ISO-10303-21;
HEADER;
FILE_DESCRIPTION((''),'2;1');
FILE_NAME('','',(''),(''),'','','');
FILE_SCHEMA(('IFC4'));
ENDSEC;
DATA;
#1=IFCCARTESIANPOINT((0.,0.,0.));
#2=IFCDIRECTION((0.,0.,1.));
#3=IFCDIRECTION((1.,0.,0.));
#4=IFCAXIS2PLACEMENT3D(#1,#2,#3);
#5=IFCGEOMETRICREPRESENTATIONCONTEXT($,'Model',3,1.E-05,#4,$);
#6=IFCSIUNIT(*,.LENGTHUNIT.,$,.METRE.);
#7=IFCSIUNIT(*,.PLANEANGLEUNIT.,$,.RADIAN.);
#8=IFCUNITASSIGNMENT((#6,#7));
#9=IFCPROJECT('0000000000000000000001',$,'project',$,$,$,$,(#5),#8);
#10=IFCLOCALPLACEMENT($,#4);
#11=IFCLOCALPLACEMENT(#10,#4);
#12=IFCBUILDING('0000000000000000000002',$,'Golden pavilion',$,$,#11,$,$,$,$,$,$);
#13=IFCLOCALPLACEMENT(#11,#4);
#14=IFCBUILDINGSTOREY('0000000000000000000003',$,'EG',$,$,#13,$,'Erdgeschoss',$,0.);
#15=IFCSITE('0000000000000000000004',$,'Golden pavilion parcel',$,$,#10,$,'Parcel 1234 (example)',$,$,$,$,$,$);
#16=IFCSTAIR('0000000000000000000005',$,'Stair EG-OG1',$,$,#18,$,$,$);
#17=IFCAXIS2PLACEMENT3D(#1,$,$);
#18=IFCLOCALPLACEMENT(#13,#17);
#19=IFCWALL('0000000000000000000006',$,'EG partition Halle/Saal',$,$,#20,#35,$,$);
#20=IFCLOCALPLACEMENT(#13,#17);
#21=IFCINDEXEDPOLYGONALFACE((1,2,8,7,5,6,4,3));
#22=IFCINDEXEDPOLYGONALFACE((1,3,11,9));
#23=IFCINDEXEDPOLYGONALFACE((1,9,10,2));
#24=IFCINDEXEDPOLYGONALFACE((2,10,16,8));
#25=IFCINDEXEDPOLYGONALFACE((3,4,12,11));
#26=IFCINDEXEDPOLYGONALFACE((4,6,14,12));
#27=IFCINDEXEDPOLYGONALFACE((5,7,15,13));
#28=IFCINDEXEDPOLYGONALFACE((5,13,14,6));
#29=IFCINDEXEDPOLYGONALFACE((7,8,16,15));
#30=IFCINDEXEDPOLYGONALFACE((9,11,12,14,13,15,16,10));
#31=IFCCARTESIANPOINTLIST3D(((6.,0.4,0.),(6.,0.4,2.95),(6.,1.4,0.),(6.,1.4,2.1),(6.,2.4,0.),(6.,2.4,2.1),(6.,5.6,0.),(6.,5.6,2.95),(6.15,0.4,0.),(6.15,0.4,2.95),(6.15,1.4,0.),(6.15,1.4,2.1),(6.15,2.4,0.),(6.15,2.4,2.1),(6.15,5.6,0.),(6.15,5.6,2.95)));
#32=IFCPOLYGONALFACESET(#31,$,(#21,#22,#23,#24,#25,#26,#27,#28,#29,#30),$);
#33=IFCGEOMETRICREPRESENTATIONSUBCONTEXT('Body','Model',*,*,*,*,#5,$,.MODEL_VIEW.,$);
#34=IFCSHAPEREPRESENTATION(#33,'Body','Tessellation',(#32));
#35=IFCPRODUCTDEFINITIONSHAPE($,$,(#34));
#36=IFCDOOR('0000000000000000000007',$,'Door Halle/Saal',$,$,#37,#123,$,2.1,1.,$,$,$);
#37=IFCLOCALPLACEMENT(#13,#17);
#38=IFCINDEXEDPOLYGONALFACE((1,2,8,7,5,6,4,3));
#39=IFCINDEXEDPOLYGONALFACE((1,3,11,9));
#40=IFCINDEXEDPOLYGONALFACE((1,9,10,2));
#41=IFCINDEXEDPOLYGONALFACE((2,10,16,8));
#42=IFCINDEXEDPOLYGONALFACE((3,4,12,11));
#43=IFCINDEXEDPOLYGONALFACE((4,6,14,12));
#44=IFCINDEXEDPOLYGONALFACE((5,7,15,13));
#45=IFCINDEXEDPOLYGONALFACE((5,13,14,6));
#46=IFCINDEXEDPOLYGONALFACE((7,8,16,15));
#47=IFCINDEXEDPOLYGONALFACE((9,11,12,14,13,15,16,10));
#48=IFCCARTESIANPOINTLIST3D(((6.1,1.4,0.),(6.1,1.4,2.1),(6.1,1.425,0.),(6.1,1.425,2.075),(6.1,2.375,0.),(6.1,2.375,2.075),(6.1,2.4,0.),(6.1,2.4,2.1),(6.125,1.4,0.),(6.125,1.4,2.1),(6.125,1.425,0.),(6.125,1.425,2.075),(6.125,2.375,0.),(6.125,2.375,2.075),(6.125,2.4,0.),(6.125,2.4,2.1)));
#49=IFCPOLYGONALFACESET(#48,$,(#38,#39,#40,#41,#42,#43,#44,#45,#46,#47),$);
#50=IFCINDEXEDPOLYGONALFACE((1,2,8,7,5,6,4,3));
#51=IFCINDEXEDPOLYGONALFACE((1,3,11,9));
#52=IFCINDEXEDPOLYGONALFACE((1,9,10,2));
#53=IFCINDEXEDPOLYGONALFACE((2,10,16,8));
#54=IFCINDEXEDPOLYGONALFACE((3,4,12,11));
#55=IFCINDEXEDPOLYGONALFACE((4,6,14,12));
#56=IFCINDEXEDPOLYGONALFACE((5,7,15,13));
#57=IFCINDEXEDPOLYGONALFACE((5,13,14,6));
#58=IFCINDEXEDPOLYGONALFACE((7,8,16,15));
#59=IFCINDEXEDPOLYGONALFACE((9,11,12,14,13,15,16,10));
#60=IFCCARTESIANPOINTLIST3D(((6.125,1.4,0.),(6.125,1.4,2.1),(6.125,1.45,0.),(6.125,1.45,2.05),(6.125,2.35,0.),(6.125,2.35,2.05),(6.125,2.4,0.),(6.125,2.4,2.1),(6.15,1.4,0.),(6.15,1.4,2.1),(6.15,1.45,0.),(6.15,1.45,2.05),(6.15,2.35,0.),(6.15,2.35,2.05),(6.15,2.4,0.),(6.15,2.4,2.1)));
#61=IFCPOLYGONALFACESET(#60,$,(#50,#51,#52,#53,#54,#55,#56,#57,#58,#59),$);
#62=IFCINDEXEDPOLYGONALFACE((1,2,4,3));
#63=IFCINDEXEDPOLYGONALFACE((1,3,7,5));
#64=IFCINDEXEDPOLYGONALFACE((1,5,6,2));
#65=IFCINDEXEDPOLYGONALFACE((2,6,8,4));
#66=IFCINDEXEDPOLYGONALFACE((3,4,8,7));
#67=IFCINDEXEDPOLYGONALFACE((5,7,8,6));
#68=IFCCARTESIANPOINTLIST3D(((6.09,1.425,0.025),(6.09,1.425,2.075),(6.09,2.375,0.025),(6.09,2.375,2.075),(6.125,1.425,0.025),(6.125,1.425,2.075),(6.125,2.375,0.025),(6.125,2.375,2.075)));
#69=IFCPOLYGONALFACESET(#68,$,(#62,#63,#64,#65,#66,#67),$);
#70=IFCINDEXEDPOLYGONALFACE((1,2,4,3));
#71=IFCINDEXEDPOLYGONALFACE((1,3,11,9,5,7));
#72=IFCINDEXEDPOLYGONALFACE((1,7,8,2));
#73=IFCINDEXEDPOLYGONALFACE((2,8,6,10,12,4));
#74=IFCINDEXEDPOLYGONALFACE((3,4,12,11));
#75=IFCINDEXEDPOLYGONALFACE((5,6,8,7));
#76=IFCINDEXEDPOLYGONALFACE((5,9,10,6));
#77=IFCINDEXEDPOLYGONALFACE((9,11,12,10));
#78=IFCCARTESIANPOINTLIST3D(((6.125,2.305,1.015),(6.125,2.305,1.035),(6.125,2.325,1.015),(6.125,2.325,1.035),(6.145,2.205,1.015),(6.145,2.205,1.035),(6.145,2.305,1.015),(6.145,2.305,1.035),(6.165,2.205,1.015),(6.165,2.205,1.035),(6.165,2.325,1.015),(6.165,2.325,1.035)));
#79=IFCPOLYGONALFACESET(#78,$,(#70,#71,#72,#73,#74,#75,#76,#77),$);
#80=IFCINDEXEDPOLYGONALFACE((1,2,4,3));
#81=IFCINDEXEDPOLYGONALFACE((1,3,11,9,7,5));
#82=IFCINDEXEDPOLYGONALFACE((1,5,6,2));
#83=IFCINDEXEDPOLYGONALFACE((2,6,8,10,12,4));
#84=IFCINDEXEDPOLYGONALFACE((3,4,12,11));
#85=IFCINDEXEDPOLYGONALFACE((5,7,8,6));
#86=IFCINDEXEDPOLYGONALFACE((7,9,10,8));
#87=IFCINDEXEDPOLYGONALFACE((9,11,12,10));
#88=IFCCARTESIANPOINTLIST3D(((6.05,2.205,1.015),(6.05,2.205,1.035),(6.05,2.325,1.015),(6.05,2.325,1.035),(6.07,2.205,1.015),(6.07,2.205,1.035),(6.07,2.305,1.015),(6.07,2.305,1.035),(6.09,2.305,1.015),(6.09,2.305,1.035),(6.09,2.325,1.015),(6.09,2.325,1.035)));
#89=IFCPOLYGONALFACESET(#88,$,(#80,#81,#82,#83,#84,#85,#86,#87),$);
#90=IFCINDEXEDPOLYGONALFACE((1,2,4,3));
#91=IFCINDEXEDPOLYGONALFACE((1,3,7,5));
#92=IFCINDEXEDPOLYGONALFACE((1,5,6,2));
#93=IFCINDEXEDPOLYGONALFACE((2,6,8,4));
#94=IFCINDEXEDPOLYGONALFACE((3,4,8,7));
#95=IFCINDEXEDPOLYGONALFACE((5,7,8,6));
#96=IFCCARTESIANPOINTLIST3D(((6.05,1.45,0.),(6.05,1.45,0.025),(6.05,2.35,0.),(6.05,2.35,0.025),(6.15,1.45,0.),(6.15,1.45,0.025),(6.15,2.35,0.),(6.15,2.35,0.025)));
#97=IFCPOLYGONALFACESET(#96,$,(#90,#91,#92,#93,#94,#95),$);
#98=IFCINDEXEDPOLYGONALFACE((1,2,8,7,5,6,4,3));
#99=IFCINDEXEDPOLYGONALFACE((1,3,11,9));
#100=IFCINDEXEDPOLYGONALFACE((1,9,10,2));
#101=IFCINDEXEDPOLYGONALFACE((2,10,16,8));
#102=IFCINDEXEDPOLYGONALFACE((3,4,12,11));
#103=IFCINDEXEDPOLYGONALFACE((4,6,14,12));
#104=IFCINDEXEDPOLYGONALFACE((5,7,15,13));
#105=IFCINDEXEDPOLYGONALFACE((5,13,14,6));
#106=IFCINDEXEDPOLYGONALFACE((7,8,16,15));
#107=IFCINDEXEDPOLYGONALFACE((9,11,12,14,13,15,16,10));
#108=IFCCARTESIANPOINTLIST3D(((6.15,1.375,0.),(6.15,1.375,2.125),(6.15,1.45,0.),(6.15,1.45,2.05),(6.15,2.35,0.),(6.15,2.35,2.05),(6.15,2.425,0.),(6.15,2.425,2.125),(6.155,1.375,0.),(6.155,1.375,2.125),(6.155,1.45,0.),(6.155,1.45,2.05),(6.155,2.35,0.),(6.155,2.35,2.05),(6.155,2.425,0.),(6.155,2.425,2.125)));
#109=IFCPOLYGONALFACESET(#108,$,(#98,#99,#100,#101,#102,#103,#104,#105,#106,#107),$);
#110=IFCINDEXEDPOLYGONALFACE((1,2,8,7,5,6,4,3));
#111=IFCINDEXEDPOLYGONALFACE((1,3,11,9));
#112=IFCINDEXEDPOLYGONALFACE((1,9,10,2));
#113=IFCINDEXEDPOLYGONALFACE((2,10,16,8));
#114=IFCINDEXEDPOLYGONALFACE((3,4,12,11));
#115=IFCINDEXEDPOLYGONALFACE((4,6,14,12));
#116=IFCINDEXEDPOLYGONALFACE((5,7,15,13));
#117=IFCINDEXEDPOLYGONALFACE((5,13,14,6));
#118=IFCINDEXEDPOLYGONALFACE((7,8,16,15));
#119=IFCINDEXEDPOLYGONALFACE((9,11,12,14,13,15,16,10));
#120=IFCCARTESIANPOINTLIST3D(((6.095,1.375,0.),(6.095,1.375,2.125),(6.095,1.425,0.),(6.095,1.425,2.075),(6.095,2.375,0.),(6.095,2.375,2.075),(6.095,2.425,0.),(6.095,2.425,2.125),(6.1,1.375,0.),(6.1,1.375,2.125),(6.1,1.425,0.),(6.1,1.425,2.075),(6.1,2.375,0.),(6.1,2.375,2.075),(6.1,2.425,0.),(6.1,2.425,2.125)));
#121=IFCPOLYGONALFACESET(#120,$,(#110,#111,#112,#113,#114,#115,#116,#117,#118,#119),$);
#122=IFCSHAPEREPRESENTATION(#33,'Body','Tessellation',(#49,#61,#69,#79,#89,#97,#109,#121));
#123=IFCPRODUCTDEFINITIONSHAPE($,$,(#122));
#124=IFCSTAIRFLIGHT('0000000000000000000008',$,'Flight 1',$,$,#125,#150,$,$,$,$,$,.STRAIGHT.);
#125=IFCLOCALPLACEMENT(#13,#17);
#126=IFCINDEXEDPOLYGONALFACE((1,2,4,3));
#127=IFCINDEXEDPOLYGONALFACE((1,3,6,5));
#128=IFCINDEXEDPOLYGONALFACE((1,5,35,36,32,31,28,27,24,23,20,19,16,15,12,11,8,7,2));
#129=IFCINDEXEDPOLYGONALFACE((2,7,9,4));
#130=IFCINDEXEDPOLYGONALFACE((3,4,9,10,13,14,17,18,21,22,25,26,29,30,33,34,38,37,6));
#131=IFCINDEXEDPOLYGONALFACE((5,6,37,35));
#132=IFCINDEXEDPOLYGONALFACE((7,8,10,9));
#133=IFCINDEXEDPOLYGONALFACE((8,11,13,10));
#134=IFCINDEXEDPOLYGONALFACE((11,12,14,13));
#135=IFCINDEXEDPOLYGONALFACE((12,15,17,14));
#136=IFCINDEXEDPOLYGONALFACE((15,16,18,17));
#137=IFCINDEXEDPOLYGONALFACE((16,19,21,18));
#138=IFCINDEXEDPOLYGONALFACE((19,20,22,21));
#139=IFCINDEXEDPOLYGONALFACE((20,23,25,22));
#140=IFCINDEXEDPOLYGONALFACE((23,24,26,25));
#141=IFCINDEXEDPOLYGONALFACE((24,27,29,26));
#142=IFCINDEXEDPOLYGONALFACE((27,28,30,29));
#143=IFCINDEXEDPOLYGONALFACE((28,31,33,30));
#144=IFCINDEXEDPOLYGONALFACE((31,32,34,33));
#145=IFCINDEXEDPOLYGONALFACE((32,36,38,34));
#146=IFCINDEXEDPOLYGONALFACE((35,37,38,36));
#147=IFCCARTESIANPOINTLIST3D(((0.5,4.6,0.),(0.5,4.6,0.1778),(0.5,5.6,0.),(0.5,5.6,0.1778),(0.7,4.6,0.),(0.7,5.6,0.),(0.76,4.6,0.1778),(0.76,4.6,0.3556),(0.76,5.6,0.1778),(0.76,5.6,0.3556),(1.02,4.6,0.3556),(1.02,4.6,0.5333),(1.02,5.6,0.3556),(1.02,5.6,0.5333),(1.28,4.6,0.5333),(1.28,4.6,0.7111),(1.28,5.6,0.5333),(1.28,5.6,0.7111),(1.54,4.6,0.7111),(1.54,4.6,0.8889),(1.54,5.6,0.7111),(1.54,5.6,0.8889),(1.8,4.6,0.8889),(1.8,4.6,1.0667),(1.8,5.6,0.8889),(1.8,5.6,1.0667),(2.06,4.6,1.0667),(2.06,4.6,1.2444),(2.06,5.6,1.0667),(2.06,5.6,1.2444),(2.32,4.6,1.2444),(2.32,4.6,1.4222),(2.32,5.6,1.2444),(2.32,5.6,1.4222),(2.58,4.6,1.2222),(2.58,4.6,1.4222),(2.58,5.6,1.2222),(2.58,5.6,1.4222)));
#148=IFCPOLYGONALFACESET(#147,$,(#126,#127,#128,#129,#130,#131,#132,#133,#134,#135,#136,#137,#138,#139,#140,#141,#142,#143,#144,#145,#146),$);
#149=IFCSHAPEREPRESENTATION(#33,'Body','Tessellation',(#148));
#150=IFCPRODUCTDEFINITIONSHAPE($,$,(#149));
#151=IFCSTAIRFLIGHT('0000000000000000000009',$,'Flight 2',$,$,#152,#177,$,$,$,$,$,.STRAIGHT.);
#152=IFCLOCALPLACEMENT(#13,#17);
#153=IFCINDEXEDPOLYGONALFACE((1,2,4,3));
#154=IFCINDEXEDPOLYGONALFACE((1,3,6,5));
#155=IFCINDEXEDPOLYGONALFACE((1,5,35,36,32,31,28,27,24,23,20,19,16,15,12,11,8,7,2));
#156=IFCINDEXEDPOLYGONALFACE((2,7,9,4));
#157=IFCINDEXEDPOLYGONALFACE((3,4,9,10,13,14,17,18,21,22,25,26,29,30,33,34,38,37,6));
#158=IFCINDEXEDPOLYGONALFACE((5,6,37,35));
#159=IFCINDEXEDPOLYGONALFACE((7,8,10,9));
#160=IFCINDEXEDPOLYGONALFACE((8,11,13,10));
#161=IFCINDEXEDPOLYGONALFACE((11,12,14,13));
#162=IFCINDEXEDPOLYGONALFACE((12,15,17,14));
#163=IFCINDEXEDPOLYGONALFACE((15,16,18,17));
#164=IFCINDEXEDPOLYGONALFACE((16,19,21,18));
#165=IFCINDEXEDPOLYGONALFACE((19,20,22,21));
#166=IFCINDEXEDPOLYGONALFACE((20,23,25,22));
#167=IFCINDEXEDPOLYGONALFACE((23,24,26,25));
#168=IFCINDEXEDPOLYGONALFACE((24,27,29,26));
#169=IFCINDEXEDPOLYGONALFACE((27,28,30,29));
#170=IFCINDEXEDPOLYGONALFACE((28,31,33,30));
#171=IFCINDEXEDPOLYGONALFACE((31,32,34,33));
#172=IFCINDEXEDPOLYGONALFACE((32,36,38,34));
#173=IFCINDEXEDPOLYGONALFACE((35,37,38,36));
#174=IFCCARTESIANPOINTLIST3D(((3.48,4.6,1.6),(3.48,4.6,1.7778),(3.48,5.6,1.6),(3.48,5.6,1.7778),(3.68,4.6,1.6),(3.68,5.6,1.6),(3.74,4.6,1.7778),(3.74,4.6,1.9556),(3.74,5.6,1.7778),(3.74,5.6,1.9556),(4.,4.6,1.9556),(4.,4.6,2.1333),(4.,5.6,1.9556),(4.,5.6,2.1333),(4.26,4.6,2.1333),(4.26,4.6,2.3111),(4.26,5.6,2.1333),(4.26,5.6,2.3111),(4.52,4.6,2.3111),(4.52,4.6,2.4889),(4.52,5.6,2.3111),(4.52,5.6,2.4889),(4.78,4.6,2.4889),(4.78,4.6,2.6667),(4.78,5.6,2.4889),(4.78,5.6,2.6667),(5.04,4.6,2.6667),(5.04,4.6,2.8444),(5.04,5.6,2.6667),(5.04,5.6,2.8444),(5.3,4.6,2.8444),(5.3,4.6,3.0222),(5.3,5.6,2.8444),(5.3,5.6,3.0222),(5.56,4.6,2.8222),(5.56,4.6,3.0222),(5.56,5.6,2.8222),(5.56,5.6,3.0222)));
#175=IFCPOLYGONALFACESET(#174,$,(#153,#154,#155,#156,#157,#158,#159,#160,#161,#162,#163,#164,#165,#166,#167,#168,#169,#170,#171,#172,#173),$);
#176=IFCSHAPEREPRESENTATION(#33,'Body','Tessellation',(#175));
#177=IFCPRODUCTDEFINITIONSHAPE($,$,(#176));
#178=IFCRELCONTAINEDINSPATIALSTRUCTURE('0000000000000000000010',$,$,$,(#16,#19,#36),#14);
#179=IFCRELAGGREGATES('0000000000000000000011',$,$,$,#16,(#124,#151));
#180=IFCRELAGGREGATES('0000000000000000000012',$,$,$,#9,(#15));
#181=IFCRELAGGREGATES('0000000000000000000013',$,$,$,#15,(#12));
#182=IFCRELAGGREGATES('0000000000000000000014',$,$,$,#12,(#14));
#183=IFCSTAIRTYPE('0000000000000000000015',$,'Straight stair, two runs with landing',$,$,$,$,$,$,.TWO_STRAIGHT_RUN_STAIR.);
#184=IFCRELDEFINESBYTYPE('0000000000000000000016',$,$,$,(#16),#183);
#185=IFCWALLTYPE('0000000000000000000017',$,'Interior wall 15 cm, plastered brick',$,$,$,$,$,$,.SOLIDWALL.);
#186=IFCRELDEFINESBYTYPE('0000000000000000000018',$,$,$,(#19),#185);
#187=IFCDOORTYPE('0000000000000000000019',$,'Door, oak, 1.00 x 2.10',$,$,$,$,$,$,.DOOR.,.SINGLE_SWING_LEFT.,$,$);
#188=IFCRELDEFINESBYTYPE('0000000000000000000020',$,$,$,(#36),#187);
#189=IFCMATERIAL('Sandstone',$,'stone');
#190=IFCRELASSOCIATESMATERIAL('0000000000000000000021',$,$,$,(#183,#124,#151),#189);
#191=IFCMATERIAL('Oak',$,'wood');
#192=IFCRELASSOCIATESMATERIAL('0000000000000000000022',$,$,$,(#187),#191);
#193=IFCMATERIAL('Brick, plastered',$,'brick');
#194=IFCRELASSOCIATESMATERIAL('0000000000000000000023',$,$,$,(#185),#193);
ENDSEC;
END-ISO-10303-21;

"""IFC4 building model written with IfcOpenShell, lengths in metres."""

from ifc_helpers import new_model, si_unit, frame, origin_with_axes, place, context, subcontext, project, spatial, line, indexed_curve, outline, extrude, source, transform, mapped, material, type_object, type_shapes, element, fill, aggregate, save


model = new_model("IFC4")

# Units and contexts
model_context = context("Model", 3, precision=1e-05, world=origin_with_axes())
body_context = subcontext(model_context, "Body", "Model", "MODEL_VIEW")
ifc_project = project(units=[si_unit("LENGTHUNIT", "METRE"), si_unit("PLANEANGLEUNIT", "RADIAN")], contexts=[model_context])

# Site, building, storey
site_placement = place(None, origin_with_axes())
site = spatial("IfcSite", under=ifc_project, at=site_placement, Name="Golden pavilion parcel", LongName="Parcel 1234 (example)")
building_placement = place(site_placement, origin_with_axes())
building = spatial("IfcBuilding", under=site, at=building_placement, Name="Golden pavilion")
storey_placement = place(building_placement, origin_with_axes())
storey = spatial("IfcBuildingStorey", under=building, at=storey_placement, Name="EG", LongName="Erdgeschoss", Elevation=0.0)

# Shared definitions
ifc_material_1 = material(Name="Sandstone", Category="stone")

# Stair
stair_type = type_object("IfcStairType", Name="Straight stair, two runs with landing", PredefinedType="TWO_STRAIGHT_RUN_STAIR", material=ifc_material_1)
stair_placement = place(storey_placement, frame((0.5, 4.6, 0.0), z_axis=(0.0, 0.0, 1.0), x_axis=(1.0, 0.0, 0.0)))
stair = element("IfcStair", 1, at=stair_placement, inside=storey, type_object=stair_type, Name="Stair EG-OG1")

# Shared definitions
ifc_material_2 = material(Name="Oak", Category="wood")
door_type = type_object("IfcDoorType", Name="Door, oak, 1.00 x 2.10", OperationType="SINGLE_SWING_LEFT", PredefinedType="DOOR", material=ifc_material_2)
shared_shape_1 = source(origin_with_axes(), body_context, "Body", "SweptSolid", [
    extrude(outline(indexed_curve([(0.0, 0.0), (0.0, 2.1), (1.0, 2.1), (1.0, 0.0), (0.975, 0.0), (0.975, 2.075), (0.025, 2.075), (0.025, 0.0)], segments=[line(1, 2, 3, 4, 5, 6, 7, 8, 1)])), frame((0.0, 0.025, 0.0), z_axis=(0.0, -1.0, 0.0), x_axis=(1.0, 0.0, 0.0)), (0.0, 0.0, -1.0), 0.025),
    extrude(outline(indexed_curve([(0.0, 0.0), (0.0, 2.1), (1.0, 2.1), (1.0, 0.0), (0.95, 0.0), (0.95, 2.05), (0.05, 2.05), (0.05, 0.0)], segments=[line(1, 2, 3, 4, 5, 6, 7, 8, 1)])), frame((0.0, 0.0, 0.0), z_axis=(0.0, -1.0, 0.0), x_axis=(1.0, 0.0, 0.0)), (0.0, 0.0, -1.0), 0.025),
    extrude(outline(indexed_curve([(0.0, 0.0), (0.95, 0.0), (0.95, 0.035), (0.0, 0.035)], segments=[line(1, 2, 3, 4, 1)])), frame((0.025, 0.025, 0.025), z_axis=(0.0, 0.0, 1.0), x_axis=(1.0, 0.0, 0.0)), (0.0, 0.0, 1.0), 2.05),
    extrude(outline(indexed_curve([(0.0, 0.0), (0.0, -0.04), (-0.12, -0.04), (-0.12, -0.02), (-0.02, -0.02), (-0.02, 0.0)], segments=[line(1, 2, 3, 4, 5, 6, 1)])), frame((0.925, 0.025, 1.015), z_axis=(0.0, 0.0, 1.0), x_axis=(1.0, 0.0, 0.0)), (0.0, 0.0, 1.0), 0.02),
    extrude(outline(indexed_curve([(0.0, 0.0), (0.0, 0.04), (-0.12, 0.04), (-0.12, 0.02), (-0.02, 0.02), (-0.02, 0.0)], segments=[line(1, 2, 3, 4, 5, 6, 1)])), frame((0.925, 0.06, 1.015), z_axis=(0.0, 0.0, 1.0), x_axis=(1.0, 0.0, 0.0)), (0.0, 0.0, 1.0), 0.02),
    extrude(outline(indexed_curve([(0.0, 0.0), (0.9, 0.0), (0.9, 0.1), (0.0, 0.1)], segments=[line(1, 2, 3, 4, 1)])), frame((0.05, 0.0, 0.0), z_axis=(0.0, 0.0, 1.0), x_axis=(1.0, 0.0, 0.0)), (0.0, 0.0, 1.0), 0.025),
    extrude(outline(indexed_curve([(0.0, 0.0), (0.0, 2.125), (1.05, 2.125), (1.05, 0.0), (0.975, 0.0), (0.975, 2.05), (0.075, 2.05), (0.075, 0.0)], segments=[line(1, 2, 3, 4, 5, 6, 7, 8, 1)])), frame((-0.025, -0.005, 0.0), z_axis=(0.0, -1.0, 0.0), x_axis=(1.0, 0.0, 0.0)), (0.0, 0.0, -1.0), 0.005),
    extrude(outline(indexed_curve([(0.0, 0.0), (0.0, 2.125), (1.05, 2.125), (1.05, 0.0), (1.0, 0.0), (1.0, 2.075), (0.05, 2.075), (0.05, 0.0)], segments=[line(1, 2, 3, 4, 5, 6, 7, 8, 1)])), frame((-0.025, 0.05, 0.0), z_axis=(0.0, -1.0, 0.0), x_axis=(1.0, 0.0, 0.0)), (0.0, 0.0, -1.0), 0.005),
])
type_shapes(door_type, [shared_shape_1])

# Wall, opening, door
ifc_material_3 = material(Name="Brick, plastered", Category="brick")
wall_type_1 = type_object("IfcWallType", Name="Interior wall 15 cm, plastered brick", PredefinedType="SOLIDWALL", material=ifc_material_3)
wall_1_placement = place(storey_placement, frame((6.15, 0.4, 0.0), z_axis=(0.0, 0.0, 1.0), x_axis=(0.0, 1.0, 0.0)))
wall_1 = element("IfcWall", 2, at=wall_1_placement, inside=storey, type_object=wall_type_1, Name="EG partition Halle/Saal", context=body_context, shape_type="SweptSolid", body=[
    extrude(outline(indexed_curve([(0.0, 0.0), (0.0, 0.15), (5.2, 0.15), (5.2, 0.0), (0.0, 0.0)], self_intersect=False)), origin_with_axes(), (0.0, 0.0, 1.0), 2.95),
])
opening_1_placement = place(wall_1_placement, origin_with_axes())
opening_1 = element("IfcOpeningElement", 3, at=opening_1_placement, cuts=wall_1, PredefinedType="OPENING", context=body_context, shape_type="SweptSolid", body=[
    extrude(outline(indexed_curve([(1.0, -0.05), (2.0, -0.05), (2.0, 0.2), (1.0, 0.2)], segments=[line(1, 2, 3, 4, 1)])), origin_with_axes(), (0.0, 0.0, 1.0), 2.1),
])
door_1_placement = place(storey_placement, frame((6.15, 1.4, 0.0), z_axis=(0.0, 0.0, 1.0), x_axis=(0.0, 1.0, 0.0)))
door_1 = element("IfcDoor", 4, at=door_1_placement, inside=storey, type_object=door_type, Name="Door Halle/Saal", OverallHeight=2.1, OverallWidth=1.0, context=body_context, shape_type="MappedRepresentation", body=[
    mapped(shared_shape_1, transform((0.0, 0.0, 0.0), x_axis=(1.0, 0.0, 0.0), y_axis=(0.0, 1.0, 0.0), z_axis=(0.0, 0.0, 1.0), scale=1.0)),
])
fill(opening_1, door_1)

# Stair flights
stair_flight_1_placement = place(stair_placement, frame((0.0, 1.0, 0.0), z_axis=(0.0, 0.0, 1.0), x_axis=(1.0, 0.0, 0.0)))
stair_flight_1 = element("IfcStairFlight", 5, at=stair_flight_1_placement, material=ifc_material_1, Name="Flight 1", PredefinedType="STRAIGHT", context=body_context, shape_type="SweptSolid", body=[
    extrude(outline(indexed_curve([(0.0, 0.0), (0.0, 0.1778), (0.26, 0.1778), (0.26, 0.3556), (0.52, 0.3556), (0.52, 0.5333), (0.78, 0.5333), (0.78, 0.7111), (1.04, 0.7111), (1.04, 0.8889), (1.3, 0.8889), (1.3, 1.0667), (1.56, 1.0667), (1.56, 1.2444), (1.82, 1.2444), (1.82, 1.4222), (2.08, 1.4222), (2.08, 1.2222), (0.2, 0.0)], segments=[line(1, 2, 3, 4, 5, 6, 7, 8, 9, 10, 11, 12, 13, 14, 15, 16, 17, 18, 19, 1)])), frame((0.0, 0.0, 0.0), z_axis=(0.0, -1.0, 0.0), x_axis=(1.0, 0.0, 0.0)), (0.0, 0.0, 1.0), 1.0),
])
stair_flight_2_placement = place(stair_placement, frame((2.98, 1.0, 1.6), z_axis=(0.0, 0.0, 1.0), x_axis=(1.0, 0.0, 0.0)))
stair_flight_2 = element("IfcStairFlight", 6, at=stair_flight_2_placement, material=ifc_material_1, Name="Flight 2", PredefinedType="STRAIGHT", context=body_context, shape_type="SweptSolid", body=[
    extrude(outline(indexed_curve([(0.0, 0.0), (0.0, 0.1778), (0.26, 0.1778), (0.26, 0.3556), (0.52, 0.3556), (0.52, 0.5333), (0.78, 0.5333), (0.78, 0.7111), (1.04, 0.7111), (1.04, 0.8889), (1.3, 0.8889), (1.3, 1.0667), (1.56, 1.0667), (1.56, 1.2444), (1.82, 1.2444), (1.82, 1.4222), (2.08, 1.4222), (2.08, 1.2222), (0.2, 0.0)], segments=[line(1, 2, 3, 4, 5, 6, 7, 8, 9, 10, 11, 12, 13, 14, 15, 16, 17, 18, 19, 1)])), frame((0.0, 0.0, 0.0), z_axis=(0.0, -1.0, 0.0), x_axis=(1.0, 0.0, 0.0)), (0.0, 0.0, 1.0), 1.0),
])
aggregate(stair, [stair_flight_1, stair_flight_2])

save(model, "model.ifc")
